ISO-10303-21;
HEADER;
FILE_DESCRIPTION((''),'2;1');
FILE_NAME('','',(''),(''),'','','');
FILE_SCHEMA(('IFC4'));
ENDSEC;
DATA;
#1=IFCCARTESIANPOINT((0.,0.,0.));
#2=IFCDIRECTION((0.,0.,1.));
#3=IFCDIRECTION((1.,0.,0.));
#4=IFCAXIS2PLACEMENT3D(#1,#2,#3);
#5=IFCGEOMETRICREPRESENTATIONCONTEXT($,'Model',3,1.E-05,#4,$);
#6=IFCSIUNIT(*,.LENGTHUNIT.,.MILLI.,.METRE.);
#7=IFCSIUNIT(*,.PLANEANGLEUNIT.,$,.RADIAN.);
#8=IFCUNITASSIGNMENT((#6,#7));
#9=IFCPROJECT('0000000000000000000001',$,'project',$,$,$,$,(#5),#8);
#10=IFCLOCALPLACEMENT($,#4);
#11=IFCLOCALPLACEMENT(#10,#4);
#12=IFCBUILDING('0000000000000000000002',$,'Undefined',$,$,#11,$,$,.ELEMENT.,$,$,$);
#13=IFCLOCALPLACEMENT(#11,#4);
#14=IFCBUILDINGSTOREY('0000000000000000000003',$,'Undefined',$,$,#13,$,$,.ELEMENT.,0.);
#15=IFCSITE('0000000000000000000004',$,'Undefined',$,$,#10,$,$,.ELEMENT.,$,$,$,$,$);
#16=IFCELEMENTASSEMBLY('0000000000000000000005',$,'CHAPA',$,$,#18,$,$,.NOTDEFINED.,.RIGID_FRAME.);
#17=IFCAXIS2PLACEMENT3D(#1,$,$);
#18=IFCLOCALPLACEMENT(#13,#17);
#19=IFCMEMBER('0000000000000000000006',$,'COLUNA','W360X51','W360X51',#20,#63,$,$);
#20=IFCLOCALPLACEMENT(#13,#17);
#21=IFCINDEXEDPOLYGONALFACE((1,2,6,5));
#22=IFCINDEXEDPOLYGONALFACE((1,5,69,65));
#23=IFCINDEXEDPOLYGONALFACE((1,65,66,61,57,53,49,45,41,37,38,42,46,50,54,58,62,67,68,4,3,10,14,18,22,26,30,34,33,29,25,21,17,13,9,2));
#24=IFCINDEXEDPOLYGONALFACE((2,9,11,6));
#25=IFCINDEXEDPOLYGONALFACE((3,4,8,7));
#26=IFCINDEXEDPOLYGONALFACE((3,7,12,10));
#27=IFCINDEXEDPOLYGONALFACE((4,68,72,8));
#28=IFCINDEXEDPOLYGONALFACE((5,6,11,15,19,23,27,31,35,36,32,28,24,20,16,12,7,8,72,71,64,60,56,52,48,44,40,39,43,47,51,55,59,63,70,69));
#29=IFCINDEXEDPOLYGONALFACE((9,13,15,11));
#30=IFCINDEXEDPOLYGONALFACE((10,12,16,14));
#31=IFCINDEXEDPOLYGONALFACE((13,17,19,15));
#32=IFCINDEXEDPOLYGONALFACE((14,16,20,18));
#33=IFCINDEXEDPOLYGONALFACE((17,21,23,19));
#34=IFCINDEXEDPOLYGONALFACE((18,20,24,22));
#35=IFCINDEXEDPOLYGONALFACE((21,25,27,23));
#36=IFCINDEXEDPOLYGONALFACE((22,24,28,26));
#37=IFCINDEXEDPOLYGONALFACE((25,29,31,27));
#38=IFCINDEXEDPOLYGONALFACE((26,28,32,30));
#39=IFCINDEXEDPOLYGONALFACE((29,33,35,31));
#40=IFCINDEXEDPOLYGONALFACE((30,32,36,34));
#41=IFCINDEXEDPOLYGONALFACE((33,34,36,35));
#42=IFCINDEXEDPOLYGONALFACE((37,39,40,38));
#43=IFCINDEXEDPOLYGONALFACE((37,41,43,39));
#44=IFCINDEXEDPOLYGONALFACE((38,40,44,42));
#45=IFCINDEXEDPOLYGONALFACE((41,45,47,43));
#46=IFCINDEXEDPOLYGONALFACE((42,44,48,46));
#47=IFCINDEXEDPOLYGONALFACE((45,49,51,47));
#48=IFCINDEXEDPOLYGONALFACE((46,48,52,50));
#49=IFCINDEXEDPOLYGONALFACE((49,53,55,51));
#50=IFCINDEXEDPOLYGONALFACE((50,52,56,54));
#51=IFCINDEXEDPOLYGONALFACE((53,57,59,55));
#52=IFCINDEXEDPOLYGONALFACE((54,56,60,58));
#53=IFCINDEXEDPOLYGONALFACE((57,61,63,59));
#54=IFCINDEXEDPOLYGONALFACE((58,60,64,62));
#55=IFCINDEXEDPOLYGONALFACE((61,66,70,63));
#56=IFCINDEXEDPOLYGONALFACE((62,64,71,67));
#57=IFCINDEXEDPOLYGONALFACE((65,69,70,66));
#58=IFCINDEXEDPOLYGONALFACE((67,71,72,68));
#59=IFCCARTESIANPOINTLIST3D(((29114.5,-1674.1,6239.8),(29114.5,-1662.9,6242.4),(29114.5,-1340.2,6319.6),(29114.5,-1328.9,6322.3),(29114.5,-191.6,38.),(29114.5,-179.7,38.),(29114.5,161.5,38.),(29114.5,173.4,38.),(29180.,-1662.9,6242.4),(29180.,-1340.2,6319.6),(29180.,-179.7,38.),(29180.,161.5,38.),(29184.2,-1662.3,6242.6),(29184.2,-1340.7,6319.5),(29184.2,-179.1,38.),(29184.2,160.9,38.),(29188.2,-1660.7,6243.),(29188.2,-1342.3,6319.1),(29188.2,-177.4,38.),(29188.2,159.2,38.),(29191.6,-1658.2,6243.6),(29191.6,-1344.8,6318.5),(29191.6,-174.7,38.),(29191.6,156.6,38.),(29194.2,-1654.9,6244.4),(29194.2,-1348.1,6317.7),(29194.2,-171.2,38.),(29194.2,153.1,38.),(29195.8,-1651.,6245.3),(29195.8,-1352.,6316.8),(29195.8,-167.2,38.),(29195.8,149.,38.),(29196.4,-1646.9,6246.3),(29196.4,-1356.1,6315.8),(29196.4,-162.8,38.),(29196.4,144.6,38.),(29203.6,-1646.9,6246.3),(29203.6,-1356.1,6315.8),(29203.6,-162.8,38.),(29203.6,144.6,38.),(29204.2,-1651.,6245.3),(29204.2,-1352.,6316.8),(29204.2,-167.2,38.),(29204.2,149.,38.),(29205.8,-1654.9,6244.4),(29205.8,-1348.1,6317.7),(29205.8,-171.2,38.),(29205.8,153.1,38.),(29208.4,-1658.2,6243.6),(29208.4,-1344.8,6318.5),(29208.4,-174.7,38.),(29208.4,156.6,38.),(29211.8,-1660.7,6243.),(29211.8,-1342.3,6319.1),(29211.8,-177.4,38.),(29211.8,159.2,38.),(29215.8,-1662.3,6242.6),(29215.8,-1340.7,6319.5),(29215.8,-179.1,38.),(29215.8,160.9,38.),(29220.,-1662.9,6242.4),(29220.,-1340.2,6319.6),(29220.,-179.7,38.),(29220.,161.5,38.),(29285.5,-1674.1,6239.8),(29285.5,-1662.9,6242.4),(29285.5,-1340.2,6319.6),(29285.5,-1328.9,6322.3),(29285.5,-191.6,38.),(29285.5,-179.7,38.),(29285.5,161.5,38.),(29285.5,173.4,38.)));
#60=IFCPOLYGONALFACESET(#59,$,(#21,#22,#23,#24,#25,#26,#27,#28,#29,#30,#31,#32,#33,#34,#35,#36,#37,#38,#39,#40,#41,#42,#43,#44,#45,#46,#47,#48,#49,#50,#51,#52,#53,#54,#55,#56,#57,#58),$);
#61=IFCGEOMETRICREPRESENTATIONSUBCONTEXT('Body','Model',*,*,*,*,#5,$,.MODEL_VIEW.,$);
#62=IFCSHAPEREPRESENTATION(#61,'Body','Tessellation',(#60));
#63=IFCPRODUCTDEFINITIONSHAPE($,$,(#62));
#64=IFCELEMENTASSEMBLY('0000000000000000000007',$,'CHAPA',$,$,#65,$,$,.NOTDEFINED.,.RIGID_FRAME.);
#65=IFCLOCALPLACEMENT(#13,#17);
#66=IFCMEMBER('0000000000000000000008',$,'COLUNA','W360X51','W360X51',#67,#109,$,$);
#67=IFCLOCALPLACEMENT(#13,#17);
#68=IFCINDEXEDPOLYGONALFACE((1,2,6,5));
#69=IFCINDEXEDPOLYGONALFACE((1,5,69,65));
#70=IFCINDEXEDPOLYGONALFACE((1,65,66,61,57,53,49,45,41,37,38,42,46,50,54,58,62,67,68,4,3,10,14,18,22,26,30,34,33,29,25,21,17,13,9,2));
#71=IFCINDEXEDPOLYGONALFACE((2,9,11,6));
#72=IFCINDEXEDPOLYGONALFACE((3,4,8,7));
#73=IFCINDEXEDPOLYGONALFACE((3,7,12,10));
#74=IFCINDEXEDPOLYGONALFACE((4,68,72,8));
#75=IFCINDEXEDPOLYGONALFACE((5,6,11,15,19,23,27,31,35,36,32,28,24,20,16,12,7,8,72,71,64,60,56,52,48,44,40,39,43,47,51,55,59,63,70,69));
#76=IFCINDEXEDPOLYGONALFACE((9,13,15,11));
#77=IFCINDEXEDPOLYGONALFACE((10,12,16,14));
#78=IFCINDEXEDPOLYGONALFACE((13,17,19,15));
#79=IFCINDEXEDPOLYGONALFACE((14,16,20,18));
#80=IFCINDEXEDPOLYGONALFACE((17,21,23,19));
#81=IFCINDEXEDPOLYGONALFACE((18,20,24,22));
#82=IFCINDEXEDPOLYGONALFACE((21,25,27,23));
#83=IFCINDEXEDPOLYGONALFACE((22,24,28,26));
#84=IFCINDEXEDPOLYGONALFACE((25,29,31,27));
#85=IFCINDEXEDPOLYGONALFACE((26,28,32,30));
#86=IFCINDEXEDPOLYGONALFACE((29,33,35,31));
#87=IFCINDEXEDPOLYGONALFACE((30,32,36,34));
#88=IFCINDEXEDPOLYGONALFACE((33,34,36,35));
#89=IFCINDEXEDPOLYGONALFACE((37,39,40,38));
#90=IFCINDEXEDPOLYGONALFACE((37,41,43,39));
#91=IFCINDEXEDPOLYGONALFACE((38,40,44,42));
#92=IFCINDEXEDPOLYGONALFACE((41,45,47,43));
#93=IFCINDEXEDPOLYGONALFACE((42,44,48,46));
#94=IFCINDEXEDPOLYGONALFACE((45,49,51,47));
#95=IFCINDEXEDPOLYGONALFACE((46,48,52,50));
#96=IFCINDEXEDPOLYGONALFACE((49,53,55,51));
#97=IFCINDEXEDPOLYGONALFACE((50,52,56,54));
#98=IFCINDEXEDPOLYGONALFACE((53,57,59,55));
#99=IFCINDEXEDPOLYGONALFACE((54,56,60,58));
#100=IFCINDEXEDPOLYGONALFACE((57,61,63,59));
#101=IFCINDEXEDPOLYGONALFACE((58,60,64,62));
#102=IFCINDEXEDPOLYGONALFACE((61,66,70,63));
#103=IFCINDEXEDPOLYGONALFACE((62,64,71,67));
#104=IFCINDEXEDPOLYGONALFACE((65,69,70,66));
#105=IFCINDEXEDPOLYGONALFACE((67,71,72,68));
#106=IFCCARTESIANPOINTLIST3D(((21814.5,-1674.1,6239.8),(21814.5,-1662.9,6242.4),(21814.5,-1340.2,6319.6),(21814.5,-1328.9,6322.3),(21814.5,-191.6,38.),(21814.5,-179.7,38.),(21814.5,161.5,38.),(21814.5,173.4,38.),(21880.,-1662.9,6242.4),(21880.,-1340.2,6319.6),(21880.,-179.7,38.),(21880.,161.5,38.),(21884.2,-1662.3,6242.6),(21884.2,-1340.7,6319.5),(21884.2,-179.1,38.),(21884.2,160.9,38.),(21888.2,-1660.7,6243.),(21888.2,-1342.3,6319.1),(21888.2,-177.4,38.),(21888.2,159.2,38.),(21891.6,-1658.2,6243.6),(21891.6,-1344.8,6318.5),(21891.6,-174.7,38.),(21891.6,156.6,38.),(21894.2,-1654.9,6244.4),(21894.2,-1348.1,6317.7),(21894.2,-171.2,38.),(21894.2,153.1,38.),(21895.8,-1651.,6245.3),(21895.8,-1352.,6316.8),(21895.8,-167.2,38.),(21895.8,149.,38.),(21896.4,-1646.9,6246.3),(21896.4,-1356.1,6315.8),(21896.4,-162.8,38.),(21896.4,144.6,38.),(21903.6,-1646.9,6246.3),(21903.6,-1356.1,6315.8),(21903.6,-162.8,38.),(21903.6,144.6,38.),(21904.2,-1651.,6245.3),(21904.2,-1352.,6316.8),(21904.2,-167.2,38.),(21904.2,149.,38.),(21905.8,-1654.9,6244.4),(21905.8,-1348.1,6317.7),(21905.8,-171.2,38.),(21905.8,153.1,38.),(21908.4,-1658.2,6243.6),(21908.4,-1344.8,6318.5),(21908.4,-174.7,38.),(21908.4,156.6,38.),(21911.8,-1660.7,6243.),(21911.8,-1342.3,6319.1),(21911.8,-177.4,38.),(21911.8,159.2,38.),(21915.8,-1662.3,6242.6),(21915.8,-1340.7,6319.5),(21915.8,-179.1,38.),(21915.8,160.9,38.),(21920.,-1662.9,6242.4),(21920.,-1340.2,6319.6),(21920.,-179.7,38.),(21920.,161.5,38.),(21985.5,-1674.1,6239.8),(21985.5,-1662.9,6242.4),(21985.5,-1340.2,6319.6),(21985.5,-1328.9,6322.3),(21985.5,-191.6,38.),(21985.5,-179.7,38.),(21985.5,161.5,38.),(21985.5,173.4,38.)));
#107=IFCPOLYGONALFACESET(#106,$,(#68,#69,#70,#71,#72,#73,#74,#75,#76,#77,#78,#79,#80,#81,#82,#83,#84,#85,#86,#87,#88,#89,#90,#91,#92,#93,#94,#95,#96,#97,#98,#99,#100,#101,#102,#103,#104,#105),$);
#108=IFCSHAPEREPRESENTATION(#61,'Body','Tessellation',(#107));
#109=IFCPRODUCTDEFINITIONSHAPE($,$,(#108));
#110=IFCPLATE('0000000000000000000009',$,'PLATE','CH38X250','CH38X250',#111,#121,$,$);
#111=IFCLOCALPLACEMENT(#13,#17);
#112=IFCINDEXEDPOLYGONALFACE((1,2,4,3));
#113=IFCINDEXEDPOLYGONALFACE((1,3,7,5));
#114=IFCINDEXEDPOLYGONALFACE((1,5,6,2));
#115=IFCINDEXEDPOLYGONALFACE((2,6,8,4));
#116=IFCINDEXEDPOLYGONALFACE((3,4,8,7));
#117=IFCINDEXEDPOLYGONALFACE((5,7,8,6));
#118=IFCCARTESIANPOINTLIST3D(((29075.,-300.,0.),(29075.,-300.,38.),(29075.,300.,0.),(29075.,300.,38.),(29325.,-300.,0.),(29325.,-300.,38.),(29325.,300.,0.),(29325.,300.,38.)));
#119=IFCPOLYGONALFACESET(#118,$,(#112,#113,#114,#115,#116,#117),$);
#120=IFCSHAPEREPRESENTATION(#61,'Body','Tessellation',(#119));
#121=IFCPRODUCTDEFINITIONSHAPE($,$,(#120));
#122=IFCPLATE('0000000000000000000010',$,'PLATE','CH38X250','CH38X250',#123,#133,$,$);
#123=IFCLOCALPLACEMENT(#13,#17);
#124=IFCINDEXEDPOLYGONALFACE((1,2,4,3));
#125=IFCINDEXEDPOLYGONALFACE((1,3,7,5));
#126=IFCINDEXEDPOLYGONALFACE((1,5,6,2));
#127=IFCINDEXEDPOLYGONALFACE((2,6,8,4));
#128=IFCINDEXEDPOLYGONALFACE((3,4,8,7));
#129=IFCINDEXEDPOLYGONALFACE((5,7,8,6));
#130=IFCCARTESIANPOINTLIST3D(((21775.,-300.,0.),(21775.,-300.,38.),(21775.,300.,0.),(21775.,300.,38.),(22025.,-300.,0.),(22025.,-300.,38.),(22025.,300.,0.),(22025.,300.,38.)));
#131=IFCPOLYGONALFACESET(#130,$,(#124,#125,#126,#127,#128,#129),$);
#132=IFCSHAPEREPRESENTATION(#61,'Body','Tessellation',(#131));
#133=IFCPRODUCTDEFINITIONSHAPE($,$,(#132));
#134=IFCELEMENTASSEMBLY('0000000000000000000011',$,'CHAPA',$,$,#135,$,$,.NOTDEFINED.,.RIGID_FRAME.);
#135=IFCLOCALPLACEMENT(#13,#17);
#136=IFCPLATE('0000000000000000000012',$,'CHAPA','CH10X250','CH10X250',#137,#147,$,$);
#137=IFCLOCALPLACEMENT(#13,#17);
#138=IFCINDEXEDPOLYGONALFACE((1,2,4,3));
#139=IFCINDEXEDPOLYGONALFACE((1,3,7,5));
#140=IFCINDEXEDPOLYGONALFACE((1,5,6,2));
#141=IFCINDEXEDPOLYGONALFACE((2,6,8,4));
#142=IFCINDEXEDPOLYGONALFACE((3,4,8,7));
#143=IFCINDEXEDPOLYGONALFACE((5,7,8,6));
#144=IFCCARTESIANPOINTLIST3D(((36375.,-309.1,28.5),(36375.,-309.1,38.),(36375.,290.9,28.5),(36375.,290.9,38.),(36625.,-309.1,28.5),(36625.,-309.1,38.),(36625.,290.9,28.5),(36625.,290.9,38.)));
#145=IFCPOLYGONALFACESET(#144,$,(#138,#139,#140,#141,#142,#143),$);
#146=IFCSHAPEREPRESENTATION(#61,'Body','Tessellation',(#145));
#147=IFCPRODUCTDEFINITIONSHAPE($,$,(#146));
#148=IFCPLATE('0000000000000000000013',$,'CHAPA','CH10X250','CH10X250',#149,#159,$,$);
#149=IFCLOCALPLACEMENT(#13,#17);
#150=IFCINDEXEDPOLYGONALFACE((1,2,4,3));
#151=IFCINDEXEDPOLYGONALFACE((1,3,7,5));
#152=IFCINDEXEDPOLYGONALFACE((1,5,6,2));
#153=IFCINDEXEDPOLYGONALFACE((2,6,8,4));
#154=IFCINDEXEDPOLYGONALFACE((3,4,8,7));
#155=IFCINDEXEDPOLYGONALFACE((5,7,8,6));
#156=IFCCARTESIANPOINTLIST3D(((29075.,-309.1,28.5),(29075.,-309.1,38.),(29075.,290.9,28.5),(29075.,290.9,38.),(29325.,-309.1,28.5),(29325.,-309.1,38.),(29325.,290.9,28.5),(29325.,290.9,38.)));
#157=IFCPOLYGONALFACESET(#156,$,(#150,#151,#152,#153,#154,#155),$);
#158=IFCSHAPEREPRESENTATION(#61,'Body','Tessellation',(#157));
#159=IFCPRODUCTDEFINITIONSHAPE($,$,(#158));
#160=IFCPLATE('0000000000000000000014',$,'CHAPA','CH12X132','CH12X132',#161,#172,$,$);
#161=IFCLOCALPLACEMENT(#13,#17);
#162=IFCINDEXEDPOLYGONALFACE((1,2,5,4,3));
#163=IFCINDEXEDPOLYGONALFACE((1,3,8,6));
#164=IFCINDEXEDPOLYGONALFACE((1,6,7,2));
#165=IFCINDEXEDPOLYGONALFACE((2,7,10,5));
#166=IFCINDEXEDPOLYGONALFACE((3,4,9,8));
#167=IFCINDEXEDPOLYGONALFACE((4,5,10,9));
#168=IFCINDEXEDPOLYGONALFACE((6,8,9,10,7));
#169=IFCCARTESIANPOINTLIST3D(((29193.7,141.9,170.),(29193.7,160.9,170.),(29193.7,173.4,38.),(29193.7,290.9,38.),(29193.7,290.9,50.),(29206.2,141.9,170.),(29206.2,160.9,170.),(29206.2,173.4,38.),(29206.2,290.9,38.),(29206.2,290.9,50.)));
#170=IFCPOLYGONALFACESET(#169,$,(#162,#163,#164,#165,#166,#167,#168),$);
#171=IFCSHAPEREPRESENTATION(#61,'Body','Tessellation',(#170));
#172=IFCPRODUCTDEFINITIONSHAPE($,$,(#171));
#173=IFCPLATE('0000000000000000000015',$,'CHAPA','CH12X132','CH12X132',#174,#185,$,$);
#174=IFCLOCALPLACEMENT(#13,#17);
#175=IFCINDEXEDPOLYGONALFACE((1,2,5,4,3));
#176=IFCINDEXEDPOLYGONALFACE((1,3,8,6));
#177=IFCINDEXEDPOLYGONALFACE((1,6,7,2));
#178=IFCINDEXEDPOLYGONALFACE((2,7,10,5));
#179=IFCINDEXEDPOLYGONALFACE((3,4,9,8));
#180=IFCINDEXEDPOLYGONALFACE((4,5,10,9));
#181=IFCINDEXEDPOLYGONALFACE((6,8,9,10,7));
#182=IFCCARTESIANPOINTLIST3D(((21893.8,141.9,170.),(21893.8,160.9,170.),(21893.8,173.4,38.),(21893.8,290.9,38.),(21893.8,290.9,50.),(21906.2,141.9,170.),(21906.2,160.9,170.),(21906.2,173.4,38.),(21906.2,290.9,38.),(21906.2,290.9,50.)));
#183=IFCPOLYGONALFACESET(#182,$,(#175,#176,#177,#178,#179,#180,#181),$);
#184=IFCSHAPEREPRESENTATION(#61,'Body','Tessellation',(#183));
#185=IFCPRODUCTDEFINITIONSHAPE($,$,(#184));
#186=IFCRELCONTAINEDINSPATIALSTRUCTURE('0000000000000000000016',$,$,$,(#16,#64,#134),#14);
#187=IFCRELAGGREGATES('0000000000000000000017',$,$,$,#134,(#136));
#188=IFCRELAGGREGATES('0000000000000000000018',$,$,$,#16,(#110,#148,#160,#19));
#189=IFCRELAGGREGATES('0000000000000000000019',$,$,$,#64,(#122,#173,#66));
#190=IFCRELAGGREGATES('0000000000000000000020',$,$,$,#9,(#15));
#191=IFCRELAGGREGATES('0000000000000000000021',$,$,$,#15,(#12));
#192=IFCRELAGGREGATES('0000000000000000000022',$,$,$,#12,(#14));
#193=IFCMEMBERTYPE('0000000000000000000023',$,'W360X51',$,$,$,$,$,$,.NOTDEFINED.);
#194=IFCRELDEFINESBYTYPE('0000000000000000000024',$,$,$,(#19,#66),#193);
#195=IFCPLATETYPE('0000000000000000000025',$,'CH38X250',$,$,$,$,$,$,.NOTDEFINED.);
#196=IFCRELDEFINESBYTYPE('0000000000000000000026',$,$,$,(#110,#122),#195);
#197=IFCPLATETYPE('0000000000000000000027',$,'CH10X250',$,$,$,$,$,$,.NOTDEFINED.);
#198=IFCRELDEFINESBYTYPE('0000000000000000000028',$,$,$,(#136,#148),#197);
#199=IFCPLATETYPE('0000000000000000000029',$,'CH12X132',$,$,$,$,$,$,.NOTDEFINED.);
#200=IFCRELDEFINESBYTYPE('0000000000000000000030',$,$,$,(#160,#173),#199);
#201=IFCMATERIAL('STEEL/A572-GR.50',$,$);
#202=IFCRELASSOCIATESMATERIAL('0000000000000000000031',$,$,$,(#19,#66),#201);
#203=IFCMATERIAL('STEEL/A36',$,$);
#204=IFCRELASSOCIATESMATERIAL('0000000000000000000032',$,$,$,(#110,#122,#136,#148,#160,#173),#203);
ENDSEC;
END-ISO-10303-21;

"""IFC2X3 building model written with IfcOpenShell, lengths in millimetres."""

from ifc_helpers import new_model, si_unit, frame, origin_with_axes, origin_2d_with_axis, place, context, subcontext, project, spatial, polyline, i_section, outline, extrude, clip, halfspace, material, type_object, element, aggregate, save


model = new_model("IFC2X3")

# Units and contexts
model_context = context("Model", 3, precision=1e-05, world=origin_with_axes())
body_context = subcontext(model_context, "Body", "Model", "MODEL_VIEW")
ifc_project = project(units=[si_unit("LENGTHUNIT", "METRE", prefix="MILLI"), si_unit("PLANEANGLEUNIT", "RADIAN")], contexts=[model_context])

# Site, building, storey
site_placement = place(None, origin_with_axes())
site = spatial("IfcSite", under=ifc_project, at=site_placement, Name="Undefined", CompositionType="ELEMENT")
building_placement = place(site_placement, origin_with_axes())
building = spatial("IfcBuilding", under=site, at=building_placement, Name="Undefined", CompositionType="ELEMENT")
storey_placement = place(building_placement, origin_with_axes())
storey = spatial("IfcBuildingStorey", under=building, at=storey_placement, Name="Undefined", CompositionType="ELEMENT", Elevation=0.0)

# Element assemblies, members
assembly_1_placement = place(storey_placement, origin_with_axes())
assembly_1 = element("IfcElementAssembly", 1, at=assembly_1_placement, inside=storey, Name="CHAPA", AssemblyPlace="NOTDEFINED", PredefinedType="RIGID_FRAME")
ifc_material_1 = material(Name="STEEL/A572-GR.50")
member_type = type_object("IfcMemberType", Name="W360X51", PredefinedType="NOTDEFINED")
member_1_placement = place(assembly_1_placement, frame((29200.0, 23.3, -97.3), z_axis=(0.0, -0.972595, -0.232504), x_axis=(0.0, -0.232504, 0.972595)))
member_1 = element("IfcMember", 2, at=member_1_placement, type_object=member_type, material=ifc_material_1, Name="COLUNA", Description="W360X51", ObjectType="W360X51", context=body_context, shape_type="Clipping", body=[
    clip(clip(extrude(i_section(OverallWidth=171.0, OverallDepth=355.0, WebThickness=7.2, FlangeThickness=11.6, FilletRadius=16.4, at=origin_2d_with_axis()), frame((6558.0, 0.0, 0.0), z_axis=(-1.0, 0.0, 0.0), x_axis=(0.0, -1.0, 0.0)), (0.0, 0.0, 1.0), 6542.9), halfspace(frame((94.5, 85.5, -186.3), z_axis=(-0.972595, 0.0, 0.232504), x_axis=(0.232504, 0.0, 0.972595)), False)), halfspace(frame((96.6, 0.0, -177.5), z_axis=(0.972595, 0.0, -0.232504), x_axis=(0.0, -1.0, 0.0)), True)),
])
assembly_2_placement = place(storey_placement, origin_with_axes())
assembly_2 = element("IfcElementAssembly", 3, at=assembly_2_placement, inside=storey, Name="CHAPA", AssemblyPlace="NOTDEFINED", PredefinedType="RIGID_FRAME")
member_2_placement = place(assembly_2_placement, frame((21900.0, 23.3, -97.3), z_axis=(0.0, -0.972595, -0.232504), x_axis=(0.0, -0.232504, 0.972595)))
member_2 = element("IfcMember", 4, at=member_2_placement, type_object=member_type, material=ifc_material_1, Name="COLUNA", Description="W360X51", ObjectType="W360X51", context=body_context, shape_type="Clipping", body=[
    clip(clip(extrude(i_section(OverallWidth=171.0, OverallDepth=355.0, WebThickness=7.2, FlangeThickness=11.6, FilletRadius=16.4, at=origin_2d_with_axis()), frame((6558.0, 0.0, 0.0), z_axis=(-1.0, 0.0, 0.0), x_axis=(0.0, -1.0, 0.0)), (0.0, 0.0, 1.0), 6542.9), halfspace(frame((94.5, 85.5, -186.3), z_axis=(-0.972595, 0.0, 0.232504), x_axis=(0.232504, 0.0, 0.972595)), False)), halfspace(frame((96.6, 0.0, -177.5), z_axis=(0.972595, 0.0, -0.232504), x_axis=(0.0, -1.0, 0.0)), True)),
])

# Plates
ifc_material_2 = material(Name="STEEL/A36")
plate_type_1 = type_object("IfcPlateType", Name="CH38X250", PredefinedType="NOTDEFINED")
plate_1_placement = place(assembly_1_placement, frame((29325.0, -300.0, 19.0), z_axis=(0.0, 0.0, 1.0), x_axis=(0.0, 1.0, 0.0)))
plate_1 = element("IfcPlate", 5, at=plate_1_placement, type_object=plate_type_1, material=ifc_material_2, Name="PLATE", Description="CH38X250", ObjectType="CH38X250", context=body_context, shape_type="SweptSolid", body=[
    extrude(outline(polyline([(0.0, 0.0), (600.0, 0.0), (600.0, 250.0), (0.0, 250.0), (0.0, 0.0)])), frame((0.0, 0.0, -19.0), z_axis=(0.0, 0.0, 1.0), x_axis=(1.0, 0.0, 0.0)), (0.0, 0.0, 1.0), 38.0),
])
plate_2_placement = place(assembly_2_placement, frame((22025.0, -300.0, 19.0), z_axis=(0.0, 0.0, 1.0), x_axis=(0.0, 1.0, 0.0)))
plate_2 = element("IfcPlate", 6, at=plate_2_placement, type_object=plate_type_1, material=ifc_material_2, Name="PLATE", Description="CH38X250", ObjectType="CH38X250", context=body_context, shape_type="SweptSolid", body=[
    extrude(outline(polyline([(0.0, 0.0), (600.0, 0.0), (600.0, 250.0), (0.0, 250.0), (0.0, 0.0)])), frame((0.0, 0.0, -19.0), z_axis=(0.0, 0.0, 1.0), x_axis=(1.0, 0.0, 0.0)), (0.0, 0.0, 1.0), 38.0),
])

# Element assembly, plate
assembly_3_placement = place(storey_placement, origin_with_axes())
assembly_3 = element("IfcElementAssembly", 7, at=assembly_3_placement, inside=storey, Name="CHAPA", AssemblyPlace="NOTDEFINED", PredefinedType="RIGID_FRAME")
plate_type_2 = type_object("IfcPlateType", Name="CH10X250", PredefinedType="NOTDEFINED")
plate_3_placement = place(assembly_3_placement, frame((36375.0, -309.1, 33.2), z_axis=(0.0, 0.0, 1.0), x_axis=(1.0, 0.0, 0.0)))
plate_3 = element("IfcPlate", 8, at=plate_3_placement, type_object=plate_type_2, material=ifc_material_2, Name="CHAPA", Description="CH10X250", ObjectType="CH10X250", context=body_context, shape_type="SweptSolid", body=[
    extrude(outline(polyline([(0.0, 0.0), (250.0, 0.0), (250.0, 600.0), (0.0, 600.0), (0.0, 0.0)])), frame((0.0, 0.0, -4.8), z_axis=(0.0, 0.0, 1.0), x_axis=(1.0, 0.0, 0.0)), (0.0, 0.0, 1.0), 9.5),
])
aggregate(assembly_3, [plate_3])

# Plates
plate_4_placement = place(assembly_1_placement, frame((29075.0, -309.1, 33.2), z_axis=(0.0, 0.0, 1.0), x_axis=(1.0, 0.0, 0.0)))
plate_4 = element("IfcPlate", 9, at=plate_4_placement, type_object=plate_type_2, material=ifc_material_2, Name="CHAPA", Description="CH10X250", ObjectType="CH10X250", context=body_context, shape_type="SweptSolid", body=[
    extrude(outline(polyline([(0.0, 0.0), (250.0, 0.0), (250.0, 600.0), (0.0, 600.0), (0.0, 0.0)])), frame((0.0, 0.0, -4.8), z_axis=(0.0, 0.0, 1.0), x_axis=(1.0, 0.0, 0.0)), (0.0, 0.0, 1.0), 9.5),
])
plate_type_3 = type_object("IfcPlateType", Name="CH12X132", PredefinedType="NOTDEFINED")
plate_5_placement = place(assembly_1_placement, frame((29200.0, 173.4, 38.0), z_axis=(1.0, 0.0, 0.0), x_axis=(0.0, 1.0, 0.0)))
plate_5 = element("IfcPlate", 10, at=plate_5_placement, type_object=plate_type_3, material=ifc_material_2, Name="CHAPA", Description="CH12X132", ObjectType="CH12X132", context=body_context, shape_type="SweptSolid", body=[
    extrude(outline(polyline([(0.0, 0.0), (117.5, 0.0), (117.5, 12.0), (-12.5, 132.0), (-31.6, 132.0), (0.0, 0.0)])), frame((0.0, 0.0, -6.2), z_axis=(0.0, 0.0, 1.0), x_axis=(1.0, 0.0, 0.0)), (0.0, 0.0, 1.0), 12.5),
])
plate_6_placement = place(assembly_2_placement, frame((21900.0, 173.4, 38.0), z_axis=(1.0, 0.0, 0.0), x_axis=(0.0, 1.0, 0.0)))
plate_6 = element("IfcPlate", 11, at=plate_6_placement, type_object=plate_type_3, material=ifc_material_2, Name="CHAPA", Description="CH12X132", ObjectType="CH12X132", context=body_context, shape_type="SweptSolid", body=[
    extrude(outline(polyline([(0.0, 0.0), (117.5, 0.0), (117.5, 12.0), (-12.5, 132.0), (-31.6, 132.0), (0.0, 0.0)])), frame((0.0, 0.0, -6.2), z_axis=(0.0, 0.0, 1.0), x_axis=(1.0, 0.0, 0.0)), (0.0, 0.0, 1.0), 12.5),
])

aggregate(assembly_1, [plate_1, plate_4, plate_5, member_1])
aggregate(assembly_2, [plate_2, plate_6, member_2])

save(model, "model.ifc")
